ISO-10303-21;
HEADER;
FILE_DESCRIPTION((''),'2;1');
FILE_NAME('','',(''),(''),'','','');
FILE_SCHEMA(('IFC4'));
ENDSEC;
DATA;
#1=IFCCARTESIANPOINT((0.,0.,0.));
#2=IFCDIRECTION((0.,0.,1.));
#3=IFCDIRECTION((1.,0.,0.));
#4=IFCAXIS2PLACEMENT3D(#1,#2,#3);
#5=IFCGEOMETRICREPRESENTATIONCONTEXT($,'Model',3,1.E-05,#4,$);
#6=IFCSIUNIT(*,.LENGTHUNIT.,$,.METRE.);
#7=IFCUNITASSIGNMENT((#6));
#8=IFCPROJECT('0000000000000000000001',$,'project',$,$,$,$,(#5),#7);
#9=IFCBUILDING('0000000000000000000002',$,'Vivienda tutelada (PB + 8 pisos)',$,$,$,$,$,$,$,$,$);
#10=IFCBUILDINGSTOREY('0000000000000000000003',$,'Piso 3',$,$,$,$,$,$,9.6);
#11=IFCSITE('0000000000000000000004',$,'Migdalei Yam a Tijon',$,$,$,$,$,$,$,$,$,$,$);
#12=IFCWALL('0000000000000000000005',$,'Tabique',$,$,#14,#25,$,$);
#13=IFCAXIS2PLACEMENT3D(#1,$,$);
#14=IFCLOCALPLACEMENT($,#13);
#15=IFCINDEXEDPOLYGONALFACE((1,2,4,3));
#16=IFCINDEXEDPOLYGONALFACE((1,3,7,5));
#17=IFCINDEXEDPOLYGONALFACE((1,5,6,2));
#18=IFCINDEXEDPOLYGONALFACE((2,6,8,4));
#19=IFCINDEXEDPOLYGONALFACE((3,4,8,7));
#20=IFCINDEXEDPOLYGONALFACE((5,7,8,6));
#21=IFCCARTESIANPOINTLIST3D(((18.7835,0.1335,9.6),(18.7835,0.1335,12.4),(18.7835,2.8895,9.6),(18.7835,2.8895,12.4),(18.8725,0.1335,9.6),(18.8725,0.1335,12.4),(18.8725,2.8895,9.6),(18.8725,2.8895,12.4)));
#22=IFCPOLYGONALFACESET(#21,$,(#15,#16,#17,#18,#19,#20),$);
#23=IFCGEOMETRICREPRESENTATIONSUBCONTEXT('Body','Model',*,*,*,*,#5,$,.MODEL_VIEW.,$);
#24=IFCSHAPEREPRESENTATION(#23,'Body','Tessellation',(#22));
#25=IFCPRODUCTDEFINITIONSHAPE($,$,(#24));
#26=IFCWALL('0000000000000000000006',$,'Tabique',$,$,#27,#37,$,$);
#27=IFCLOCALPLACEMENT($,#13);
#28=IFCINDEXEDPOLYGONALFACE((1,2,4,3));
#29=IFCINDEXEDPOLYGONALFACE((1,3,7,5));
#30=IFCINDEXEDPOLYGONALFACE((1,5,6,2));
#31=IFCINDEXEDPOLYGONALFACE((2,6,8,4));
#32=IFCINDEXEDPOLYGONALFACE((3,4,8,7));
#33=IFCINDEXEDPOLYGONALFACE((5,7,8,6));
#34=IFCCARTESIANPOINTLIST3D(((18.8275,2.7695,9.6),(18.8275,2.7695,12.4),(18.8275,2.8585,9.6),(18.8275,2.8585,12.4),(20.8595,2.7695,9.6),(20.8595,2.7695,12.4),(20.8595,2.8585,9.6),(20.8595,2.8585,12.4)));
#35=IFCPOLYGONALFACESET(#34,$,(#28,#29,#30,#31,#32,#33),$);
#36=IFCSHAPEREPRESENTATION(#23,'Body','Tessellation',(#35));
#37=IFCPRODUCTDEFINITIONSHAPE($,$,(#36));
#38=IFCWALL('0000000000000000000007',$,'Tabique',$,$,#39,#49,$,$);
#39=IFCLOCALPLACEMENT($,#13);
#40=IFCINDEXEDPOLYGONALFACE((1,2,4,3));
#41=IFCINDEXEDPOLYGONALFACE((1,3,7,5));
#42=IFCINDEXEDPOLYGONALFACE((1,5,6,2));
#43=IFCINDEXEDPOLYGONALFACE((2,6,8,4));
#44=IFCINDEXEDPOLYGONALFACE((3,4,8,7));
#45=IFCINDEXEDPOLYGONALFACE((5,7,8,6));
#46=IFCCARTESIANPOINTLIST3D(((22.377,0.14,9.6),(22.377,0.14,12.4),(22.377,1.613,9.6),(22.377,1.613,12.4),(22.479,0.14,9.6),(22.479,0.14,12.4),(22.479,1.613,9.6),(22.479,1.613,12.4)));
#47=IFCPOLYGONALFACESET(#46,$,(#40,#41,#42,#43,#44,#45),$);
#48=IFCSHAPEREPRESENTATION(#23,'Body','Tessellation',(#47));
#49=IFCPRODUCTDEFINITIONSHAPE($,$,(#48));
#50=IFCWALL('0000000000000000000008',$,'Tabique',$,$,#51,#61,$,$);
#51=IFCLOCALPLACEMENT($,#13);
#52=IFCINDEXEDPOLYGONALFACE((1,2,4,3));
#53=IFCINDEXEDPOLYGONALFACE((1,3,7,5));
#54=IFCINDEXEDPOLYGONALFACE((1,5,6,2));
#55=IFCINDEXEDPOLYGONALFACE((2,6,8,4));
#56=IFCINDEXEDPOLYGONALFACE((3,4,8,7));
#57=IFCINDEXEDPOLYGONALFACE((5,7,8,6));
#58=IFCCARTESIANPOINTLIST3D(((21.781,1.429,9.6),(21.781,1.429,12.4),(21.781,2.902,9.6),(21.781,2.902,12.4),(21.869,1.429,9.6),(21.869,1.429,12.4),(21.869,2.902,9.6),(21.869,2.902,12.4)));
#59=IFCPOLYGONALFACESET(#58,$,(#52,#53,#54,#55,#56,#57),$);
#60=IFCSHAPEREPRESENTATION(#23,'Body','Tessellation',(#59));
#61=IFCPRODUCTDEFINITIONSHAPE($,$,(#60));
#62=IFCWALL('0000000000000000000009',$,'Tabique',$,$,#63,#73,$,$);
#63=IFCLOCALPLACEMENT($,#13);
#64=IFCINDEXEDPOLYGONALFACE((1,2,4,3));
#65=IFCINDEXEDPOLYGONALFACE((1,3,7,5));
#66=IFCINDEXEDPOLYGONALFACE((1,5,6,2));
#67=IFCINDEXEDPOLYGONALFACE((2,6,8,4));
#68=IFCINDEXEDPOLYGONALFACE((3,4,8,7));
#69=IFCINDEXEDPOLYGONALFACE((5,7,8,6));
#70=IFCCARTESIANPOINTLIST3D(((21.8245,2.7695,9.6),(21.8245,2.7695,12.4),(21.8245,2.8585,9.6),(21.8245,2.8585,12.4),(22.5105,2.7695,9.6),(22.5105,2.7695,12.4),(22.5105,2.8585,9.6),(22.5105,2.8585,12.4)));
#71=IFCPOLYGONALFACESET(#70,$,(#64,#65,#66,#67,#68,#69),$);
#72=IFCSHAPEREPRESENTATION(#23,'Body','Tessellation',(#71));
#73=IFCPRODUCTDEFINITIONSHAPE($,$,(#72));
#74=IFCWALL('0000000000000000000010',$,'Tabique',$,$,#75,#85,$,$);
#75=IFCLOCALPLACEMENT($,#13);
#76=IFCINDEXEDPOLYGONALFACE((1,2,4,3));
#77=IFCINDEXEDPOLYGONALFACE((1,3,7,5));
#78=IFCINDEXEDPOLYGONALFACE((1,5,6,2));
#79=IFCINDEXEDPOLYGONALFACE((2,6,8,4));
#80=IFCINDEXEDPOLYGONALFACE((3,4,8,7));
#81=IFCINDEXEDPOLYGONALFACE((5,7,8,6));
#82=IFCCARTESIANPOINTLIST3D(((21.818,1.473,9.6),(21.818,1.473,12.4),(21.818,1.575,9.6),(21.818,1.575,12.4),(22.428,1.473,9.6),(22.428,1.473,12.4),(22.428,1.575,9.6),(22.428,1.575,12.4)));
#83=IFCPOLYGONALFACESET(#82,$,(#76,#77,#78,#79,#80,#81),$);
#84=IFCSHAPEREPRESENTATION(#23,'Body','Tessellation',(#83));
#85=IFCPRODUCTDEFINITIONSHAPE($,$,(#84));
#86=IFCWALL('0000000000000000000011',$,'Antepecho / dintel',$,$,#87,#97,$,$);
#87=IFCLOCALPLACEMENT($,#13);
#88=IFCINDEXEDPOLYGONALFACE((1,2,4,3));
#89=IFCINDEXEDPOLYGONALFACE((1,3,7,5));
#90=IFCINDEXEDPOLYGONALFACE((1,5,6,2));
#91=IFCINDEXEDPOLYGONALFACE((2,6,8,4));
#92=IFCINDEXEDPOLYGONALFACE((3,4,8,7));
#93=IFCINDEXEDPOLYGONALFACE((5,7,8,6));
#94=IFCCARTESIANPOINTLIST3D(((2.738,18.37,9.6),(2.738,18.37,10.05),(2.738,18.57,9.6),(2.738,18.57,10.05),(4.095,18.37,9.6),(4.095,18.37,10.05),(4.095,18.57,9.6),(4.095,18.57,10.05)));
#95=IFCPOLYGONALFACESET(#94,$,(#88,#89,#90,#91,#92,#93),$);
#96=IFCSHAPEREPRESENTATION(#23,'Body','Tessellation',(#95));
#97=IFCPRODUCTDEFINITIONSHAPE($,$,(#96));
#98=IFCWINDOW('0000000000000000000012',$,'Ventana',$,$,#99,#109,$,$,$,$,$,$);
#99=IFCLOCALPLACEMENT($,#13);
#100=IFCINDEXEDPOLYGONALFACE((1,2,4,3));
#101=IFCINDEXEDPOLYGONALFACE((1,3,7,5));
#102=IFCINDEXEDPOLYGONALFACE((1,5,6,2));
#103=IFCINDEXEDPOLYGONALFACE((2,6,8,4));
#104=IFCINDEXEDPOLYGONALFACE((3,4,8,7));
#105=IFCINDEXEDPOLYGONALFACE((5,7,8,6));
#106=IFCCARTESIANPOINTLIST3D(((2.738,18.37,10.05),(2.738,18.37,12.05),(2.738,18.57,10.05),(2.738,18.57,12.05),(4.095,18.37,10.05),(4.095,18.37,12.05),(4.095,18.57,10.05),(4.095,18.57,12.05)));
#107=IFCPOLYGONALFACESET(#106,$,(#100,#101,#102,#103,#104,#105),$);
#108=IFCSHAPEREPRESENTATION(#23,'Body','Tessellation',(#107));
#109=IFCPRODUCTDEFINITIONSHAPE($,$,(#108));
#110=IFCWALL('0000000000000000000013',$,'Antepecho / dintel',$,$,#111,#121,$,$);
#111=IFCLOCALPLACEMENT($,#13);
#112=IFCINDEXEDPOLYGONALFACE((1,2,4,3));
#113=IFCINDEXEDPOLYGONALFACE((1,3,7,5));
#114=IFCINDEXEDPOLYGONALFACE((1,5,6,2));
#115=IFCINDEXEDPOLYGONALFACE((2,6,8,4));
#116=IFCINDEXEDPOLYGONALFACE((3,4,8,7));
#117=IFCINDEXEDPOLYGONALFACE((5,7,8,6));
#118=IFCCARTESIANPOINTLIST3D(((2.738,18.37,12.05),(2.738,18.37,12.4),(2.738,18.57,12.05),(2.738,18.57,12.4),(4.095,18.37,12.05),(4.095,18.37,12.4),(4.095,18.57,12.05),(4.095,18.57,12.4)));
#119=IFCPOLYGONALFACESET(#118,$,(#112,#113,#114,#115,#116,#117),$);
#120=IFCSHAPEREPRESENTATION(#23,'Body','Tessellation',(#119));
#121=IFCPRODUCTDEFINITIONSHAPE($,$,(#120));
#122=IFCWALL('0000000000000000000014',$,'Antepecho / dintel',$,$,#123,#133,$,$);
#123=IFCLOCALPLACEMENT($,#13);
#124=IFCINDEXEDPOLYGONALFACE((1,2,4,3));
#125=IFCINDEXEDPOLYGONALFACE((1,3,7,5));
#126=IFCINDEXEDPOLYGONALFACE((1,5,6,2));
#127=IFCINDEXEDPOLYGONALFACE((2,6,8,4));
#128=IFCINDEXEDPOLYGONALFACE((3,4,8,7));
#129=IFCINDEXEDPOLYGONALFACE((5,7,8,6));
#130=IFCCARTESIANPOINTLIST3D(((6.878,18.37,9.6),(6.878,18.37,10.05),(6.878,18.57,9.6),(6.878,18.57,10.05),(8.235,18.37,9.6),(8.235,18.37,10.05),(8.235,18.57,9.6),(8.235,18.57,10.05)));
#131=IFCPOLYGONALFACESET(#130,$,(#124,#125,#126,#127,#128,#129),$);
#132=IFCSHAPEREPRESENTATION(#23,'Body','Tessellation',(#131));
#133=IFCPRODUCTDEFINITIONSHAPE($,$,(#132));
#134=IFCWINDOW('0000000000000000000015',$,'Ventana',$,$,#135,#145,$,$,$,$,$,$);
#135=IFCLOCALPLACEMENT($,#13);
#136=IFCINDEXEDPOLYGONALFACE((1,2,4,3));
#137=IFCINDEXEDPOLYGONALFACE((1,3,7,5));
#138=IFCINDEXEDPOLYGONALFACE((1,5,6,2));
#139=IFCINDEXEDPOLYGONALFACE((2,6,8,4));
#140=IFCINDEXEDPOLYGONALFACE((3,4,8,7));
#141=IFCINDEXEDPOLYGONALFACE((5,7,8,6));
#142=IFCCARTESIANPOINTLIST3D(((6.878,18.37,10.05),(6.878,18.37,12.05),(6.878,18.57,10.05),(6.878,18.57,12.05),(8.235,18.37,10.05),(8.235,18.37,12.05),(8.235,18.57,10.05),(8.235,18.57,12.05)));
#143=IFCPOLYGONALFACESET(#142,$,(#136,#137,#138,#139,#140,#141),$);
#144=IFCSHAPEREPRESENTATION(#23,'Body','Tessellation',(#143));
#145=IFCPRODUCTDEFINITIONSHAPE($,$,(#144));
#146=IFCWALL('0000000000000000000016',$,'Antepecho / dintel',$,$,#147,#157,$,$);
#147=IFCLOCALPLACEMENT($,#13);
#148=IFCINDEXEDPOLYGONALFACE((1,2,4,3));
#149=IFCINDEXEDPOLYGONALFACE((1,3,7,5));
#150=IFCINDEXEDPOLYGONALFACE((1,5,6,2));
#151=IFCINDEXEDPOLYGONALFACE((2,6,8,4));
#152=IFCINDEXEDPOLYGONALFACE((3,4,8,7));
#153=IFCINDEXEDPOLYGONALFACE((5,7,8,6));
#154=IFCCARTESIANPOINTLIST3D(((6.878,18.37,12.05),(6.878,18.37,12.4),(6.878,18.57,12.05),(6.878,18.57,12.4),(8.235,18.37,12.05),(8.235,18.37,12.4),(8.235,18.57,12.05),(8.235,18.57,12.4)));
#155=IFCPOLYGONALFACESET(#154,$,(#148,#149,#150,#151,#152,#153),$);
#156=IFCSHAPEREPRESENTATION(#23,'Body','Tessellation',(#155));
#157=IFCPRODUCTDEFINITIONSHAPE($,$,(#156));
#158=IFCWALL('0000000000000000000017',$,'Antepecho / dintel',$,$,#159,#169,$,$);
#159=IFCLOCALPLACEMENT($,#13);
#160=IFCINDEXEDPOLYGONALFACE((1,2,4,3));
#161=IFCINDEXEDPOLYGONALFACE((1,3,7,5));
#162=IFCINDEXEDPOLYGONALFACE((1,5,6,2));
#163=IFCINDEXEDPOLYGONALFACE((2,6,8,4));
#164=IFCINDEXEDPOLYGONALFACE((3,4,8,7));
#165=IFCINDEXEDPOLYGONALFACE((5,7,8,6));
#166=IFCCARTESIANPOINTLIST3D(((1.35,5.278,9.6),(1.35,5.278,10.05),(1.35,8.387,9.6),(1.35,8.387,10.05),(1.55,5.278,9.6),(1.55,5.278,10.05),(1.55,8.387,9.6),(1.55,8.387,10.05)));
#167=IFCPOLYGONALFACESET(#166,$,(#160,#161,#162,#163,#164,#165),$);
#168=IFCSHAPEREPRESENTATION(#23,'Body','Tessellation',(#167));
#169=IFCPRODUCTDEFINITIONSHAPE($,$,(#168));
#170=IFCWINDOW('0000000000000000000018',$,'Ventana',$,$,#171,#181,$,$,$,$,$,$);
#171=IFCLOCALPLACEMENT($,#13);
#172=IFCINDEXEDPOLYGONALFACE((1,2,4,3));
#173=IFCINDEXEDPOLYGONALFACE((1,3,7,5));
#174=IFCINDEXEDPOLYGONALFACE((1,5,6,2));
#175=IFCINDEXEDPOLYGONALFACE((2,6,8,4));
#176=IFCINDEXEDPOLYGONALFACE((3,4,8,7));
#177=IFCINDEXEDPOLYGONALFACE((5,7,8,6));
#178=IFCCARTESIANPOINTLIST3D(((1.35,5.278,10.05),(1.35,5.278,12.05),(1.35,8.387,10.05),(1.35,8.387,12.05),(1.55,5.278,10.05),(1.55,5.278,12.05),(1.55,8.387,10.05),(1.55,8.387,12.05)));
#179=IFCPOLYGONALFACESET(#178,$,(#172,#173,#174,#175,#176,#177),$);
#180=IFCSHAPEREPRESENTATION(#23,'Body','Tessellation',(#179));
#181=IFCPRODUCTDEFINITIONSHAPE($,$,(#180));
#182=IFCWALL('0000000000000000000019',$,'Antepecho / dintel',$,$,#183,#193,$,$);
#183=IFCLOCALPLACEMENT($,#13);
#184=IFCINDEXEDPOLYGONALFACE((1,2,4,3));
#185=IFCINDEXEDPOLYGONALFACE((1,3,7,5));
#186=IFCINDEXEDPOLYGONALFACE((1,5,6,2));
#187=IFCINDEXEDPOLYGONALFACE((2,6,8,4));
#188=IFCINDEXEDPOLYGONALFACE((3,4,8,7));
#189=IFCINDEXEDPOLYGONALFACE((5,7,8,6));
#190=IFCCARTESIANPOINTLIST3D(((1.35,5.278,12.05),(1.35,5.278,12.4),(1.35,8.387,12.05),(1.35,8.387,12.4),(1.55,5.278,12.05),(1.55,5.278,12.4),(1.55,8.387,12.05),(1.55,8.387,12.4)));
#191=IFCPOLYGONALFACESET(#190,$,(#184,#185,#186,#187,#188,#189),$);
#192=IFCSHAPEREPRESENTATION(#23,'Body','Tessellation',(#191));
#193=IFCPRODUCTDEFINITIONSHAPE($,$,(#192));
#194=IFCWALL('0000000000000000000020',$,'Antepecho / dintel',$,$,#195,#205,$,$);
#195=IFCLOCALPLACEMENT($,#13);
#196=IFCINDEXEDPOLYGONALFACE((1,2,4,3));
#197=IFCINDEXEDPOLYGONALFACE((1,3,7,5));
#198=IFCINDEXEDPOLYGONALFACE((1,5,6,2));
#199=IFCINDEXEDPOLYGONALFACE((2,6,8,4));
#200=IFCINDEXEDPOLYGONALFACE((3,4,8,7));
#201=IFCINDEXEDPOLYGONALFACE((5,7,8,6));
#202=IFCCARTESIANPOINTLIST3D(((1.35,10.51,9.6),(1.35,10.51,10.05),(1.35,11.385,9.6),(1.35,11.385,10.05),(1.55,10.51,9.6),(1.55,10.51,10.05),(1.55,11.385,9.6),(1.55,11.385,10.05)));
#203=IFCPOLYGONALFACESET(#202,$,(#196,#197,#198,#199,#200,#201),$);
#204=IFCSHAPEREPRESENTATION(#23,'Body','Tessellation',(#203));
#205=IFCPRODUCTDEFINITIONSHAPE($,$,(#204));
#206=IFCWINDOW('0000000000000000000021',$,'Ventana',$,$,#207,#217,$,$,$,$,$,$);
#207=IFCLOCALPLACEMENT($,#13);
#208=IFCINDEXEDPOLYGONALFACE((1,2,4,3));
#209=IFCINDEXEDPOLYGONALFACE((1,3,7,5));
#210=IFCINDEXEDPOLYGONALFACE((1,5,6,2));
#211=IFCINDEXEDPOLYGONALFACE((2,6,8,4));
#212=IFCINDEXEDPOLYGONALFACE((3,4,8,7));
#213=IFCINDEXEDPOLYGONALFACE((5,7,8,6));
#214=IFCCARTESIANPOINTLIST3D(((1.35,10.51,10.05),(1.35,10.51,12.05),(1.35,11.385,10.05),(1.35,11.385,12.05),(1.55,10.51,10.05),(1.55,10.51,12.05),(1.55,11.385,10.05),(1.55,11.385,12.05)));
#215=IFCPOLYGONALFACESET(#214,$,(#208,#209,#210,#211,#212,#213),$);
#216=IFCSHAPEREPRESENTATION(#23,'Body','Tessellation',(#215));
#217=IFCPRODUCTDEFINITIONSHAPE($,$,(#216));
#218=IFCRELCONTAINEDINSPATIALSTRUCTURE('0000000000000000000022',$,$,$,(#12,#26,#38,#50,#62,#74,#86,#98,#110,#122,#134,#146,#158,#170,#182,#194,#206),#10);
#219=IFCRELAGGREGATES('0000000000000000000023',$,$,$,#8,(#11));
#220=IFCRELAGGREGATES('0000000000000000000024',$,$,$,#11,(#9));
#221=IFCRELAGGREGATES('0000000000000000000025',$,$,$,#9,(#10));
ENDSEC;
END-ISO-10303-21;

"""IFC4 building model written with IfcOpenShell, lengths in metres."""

from ifc_helpers import new_model, si_unit, frame, origin_with_axes, context, subcontext, project, spatial, line, indexed_curve, outline, extrude, element, save


model = new_model("IFC4")

# Units and contexts
model_context = context("Model", 3, precision=1e-05, world=origin_with_axes())
body_context = subcontext(model_context, "Body", "Model", "MODEL_VIEW")
ifc_project = project(units=[si_unit("LENGTHUNIT", "METRE")], contexts=[model_context])

# Site, building, storey
site = spatial("IfcSite", under=ifc_project, Name="Migdalei Yam a Tijon")
building = spatial("IfcBuilding", under=site, Name="Vivienda tutelada (PB + 8 pisos)")
storey = spatial("IfcBuildingStorey", under=building, Name="Piso 3", Elevation=9.6)

# Walls
element("IfcWall", 1, inside=storey, Name="Tabique", context=body_context, shape_type="SweptSolid", body=[
    extrude(outline(indexed_curve([(0.0, 0.0), (0.089, 0.0), (0.089, 2.756), (0.0, 2.756)], segments=[line(1, 2, 3, 4, 1)])), frame((18.7835, 0.1335, 9.6), z_axis=(0.0, 0.0, 1.0), x_axis=(1.0, 0.0, 0.0)), (0.0, 0.0, 1.0), 2.8),
])
element("IfcWall", 2, inside=storey, Name="Tabique", context=body_context, shape_type="SweptSolid", body=[
    extrude(outline(indexed_curve([(0.0, 0.0), (2.032, 0.0), (2.032, 0.089), (0.0, 0.089)], segments=[line(1, 2, 3, 4, 1)])), frame((18.8275, 2.7695, 9.6), z_axis=(0.0, 0.0, 1.0), x_axis=(1.0, 0.0, 0.0)), (0.0, 0.0, 1.0), 2.8),
])
element("IfcWall", 3, inside=storey, Name="Tabique", context=body_context, shape_type="SweptSolid", body=[
    extrude(outline(indexed_curve([(0.0, 0.0), (0.102, 0.0), (0.102, 1.473), (0.0, 1.473)], segments=[line(1, 2, 3, 4, 1)])), frame((22.377, 0.14, 9.6), z_axis=(0.0, 0.0, 1.0), x_axis=(1.0, 0.0, 0.0)), (0.0, 0.0, 1.0), 2.8),
])
element("IfcWall", 4, inside=storey, Name="Tabique", context=body_context, shape_type="SweptSolid", body=[
    extrude(outline(indexed_curve([(0.0, 0.0), (0.088, 0.0), (0.088, 1.473), (0.0, 1.473)], segments=[line(1, 2, 3, 4, 1)])), frame((21.781, 1.429, 9.6), z_axis=(0.0, 0.0, 1.0), x_axis=(1.0, 0.0, 0.0)), (0.0, 0.0, 1.0), 2.8),
])
element("IfcWall", 5, inside=storey, Name="Tabique", context=body_context, shape_type="SweptSolid", body=[
    extrude(outline(indexed_curve([(0.0, 0.0), (0.686, 0.0), (0.686, 0.089), (0.0, 0.089)], segments=[line(1, 2, 3, 4, 1)])), frame((21.8245, 2.7695, 9.6), z_axis=(0.0, 0.0, 1.0), x_axis=(1.0, 0.0, 0.0)), (0.0, 0.0, 1.0), 2.8),
])
element("IfcWall", 6, inside=storey, Name="Tabique", context=body_context, shape_type="SweptSolid", body=[
    extrude(outline(indexed_curve([(0.0, 0.0), (0.61, 0.0), (0.61, 0.102), (0.0, 0.102)], segments=[line(1, 2, 3, 4, 1)])), frame((21.818, 1.473, 9.6), z_axis=(0.0, 0.0, 1.0), x_axis=(1.0, 0.0, 0.0)), (0.0, 0.0, 1.0), 2.8),
])
element("IfcWall", 7, inside=storey, Name="Antepecho / dintel", context=body_context, shape_type="SweptSolid", body=[
    extrude(outline(indexed_curve([(0.0, 0.0), (1.357, 0.0), (1.357, 0.2), (0.0, 0.2)], segments=[line(1, 2, 3, 4, 1)])), frame((2.738, 18.37, 9.6), z_axis=(0.0, 0.0, 1.0), x_axis=(1.0, 0.0, 0.0)), (0.0, 0.0, 1.0), 0.45),
])

# Window
element("IfcWindow", 8, inside=storey, Name="Ventana", context=body_context, shape_type="SweptSolid", body=[
    extrude(outline(indexed_curve([(0.0, 0.0), (1.357, 0.0), (1.357, 0.2), (0.0, 0.2)], segments=[line(1, 2, 3, 4, 1)])), frame((2.738, 18.37, 10.05), z_axis=(0.0, 0.0, 1.0), x_axis=(1.0, 0.0, 0.0)), (0.0, 0.0, 1.0), 2.0),
])

# Walls
element("IfcWall", 9, inside=storey, Name="Antepecho / dintel", context=body_context, shape_type="SweptSolid", body=[
    extrude(outline(indexed_curve([(0.0, 0.0), (1.357, 0.0), (1.357, 0.2), (0.0, 0.2)], segments=[line(1, 2, 3, 4, 1)])), frame((2.738, 18.37, 12.05), z_axis=(0.0, 0.0, 1.0), x_axis=(1.0, 0.0, 0.0)), (0.0, 0.0, 1.0), 0.35),
])
element("IfcWall", 10, inside=storey, Name="Antepecho / dintel", context=body_context, shape_type="SweptSolid", body=[
    extrude(outline(indexed_curve([(0.0, 0.0), (1.357, 0.0), (1.357, 0.2), (0.0, 0.2)], segments=[line(1, 2, 3, 4, 1)])), frame((6.878, 18.37, 9.6), z_axis=(0.0, 0.0, 1.0), x_axis=(1.0, 0.0, 0.0)), (0.0, 0.0, 1.0), 0.45),
])

# Window
element("IfcWindow", 11, inside=storey, Name="Ventana", context=body_context, shape_type="SweptSolid", body=[
    extrude(outline(indexed_curve([(0.0, 0.0), (1.357, 0.0), (1.357, 0.2), (0.0, 0.2)], segments=[line(1, 2, 3, 4, 1)])), frame((6.878, 18.37, 10.05), z_axis=(0.0, 0.0, 1.0), x_axis=(1.0, 0.0, 0.0)), (0.0, 0.0, 1.0), 2.0),
])

# Walls
element("IfcWall", 12, inside=storey, Name="Antepecho / dintel", context=body_context, shape_type="SweptSolid", body=[
    extrude(outline(indexed_curve([(0.0, 0.0), (1.357, 0.0), (1.357, 0.2), (0.0, 0.2)], segments=[line(1, 2, 3, 4, 1)])), frame((6.878, 18.37, 12.05), z_axis=(0.0, 0.0, 1.0), x_axis=(1.0, 0.0, 0.0)), (0.0, 0.0, 1.0), 0.35),
])
element("IfcWall", 13, inside=storey, Name="Antepecho / dintel", context=body_context, shape_type="SweptSolid", body=[
    extrude(outline(indexed_curve([(0.0, 0.0), (0.2, 0.0), (0.2, 3.109), (0.0, 3.109)], segments=[line(1, 2, 3, 4, 1)])), frame((1.35, 5.278, 9.6), z_axis=(0.0, 0.0, 1.0), x_axis=(1.0, 0.0, 0.0)), (0.0, 0.0, 1.0), 0.45),
])

# Window
element("IfcWindow", 14, inside=storey, Name="Ventana", context=body_context, shape_type="SweptSolid", body=[
    extrude(outline(indexed_curve([(0.0, 0.0), (0.2, 0.0), (0.2, 3.109), (0.0, 3.109)], segments=[line(1, 2, 3, 4, 1)])), frame((1.35, 5.278, 10.05), z_axis=(0.0, 0.0, 1.0), x_axis=(1.0, 0.0, 0.0)), (0.0, 0.0, 1.0), 2.0),
])

# Walls
element("IfcWall", 15, inside=storey, Name="Antepecho / dintel", context=body_context, shape_type="SweptSolid", body=[
    extrude(outline(indexed_curve([(0.0, 0.0), (0.2, 0.0), (0.2, 3.109), (0.0, 3.109)], segments=[line(1, 2, 3, 4, 1)])), frame((1.35, 5.278, 12.05), z_axis=(0.0, 0.0, 1.0), x_axis=(1.0, 0.0, 0.0)), (0.0, 0.0, 1.0), 0.35),
])
element("IfcWall", 16, inside=storey, Name="Antepecho / dintel", context=body_context, shape_type="SweptSolid", body=[
    extrude(outline(indexed_curve([(0.0, 0.0), (0.2, 0.0), (0.2, 0.875), (0.0, 0.875)], segments=[line(1, 2, 3, 4, 1)])), frame((1.35, 10.51, 9.6), z_axis=(0.0, 0.0, 1.0), x_axis=(1.0, 0.0, 0.0)), (0.0, 0.0, 1.0), 0.45),
])

# Window
element("IfcWindow", 17, inside=storey, Name="Ventana", context=body_context, shape_type="SweptSolid", body=[
    extrude(outline(indexed_curve([(0.0, 0.0), (0.2, 0.0), (0.2, 0.875), (0.0, 0.875)], segments=[line(1, 2, 3, 4, 1)])), frame((1.35, 10.51, 10.05), z_axis=(0.0, 0.0, 1.0), x_axis=(1.0, 0.0, 0.0)), (0.0, 0.0, 1.0), 2.0),
])

save(model, "model.ifc")
